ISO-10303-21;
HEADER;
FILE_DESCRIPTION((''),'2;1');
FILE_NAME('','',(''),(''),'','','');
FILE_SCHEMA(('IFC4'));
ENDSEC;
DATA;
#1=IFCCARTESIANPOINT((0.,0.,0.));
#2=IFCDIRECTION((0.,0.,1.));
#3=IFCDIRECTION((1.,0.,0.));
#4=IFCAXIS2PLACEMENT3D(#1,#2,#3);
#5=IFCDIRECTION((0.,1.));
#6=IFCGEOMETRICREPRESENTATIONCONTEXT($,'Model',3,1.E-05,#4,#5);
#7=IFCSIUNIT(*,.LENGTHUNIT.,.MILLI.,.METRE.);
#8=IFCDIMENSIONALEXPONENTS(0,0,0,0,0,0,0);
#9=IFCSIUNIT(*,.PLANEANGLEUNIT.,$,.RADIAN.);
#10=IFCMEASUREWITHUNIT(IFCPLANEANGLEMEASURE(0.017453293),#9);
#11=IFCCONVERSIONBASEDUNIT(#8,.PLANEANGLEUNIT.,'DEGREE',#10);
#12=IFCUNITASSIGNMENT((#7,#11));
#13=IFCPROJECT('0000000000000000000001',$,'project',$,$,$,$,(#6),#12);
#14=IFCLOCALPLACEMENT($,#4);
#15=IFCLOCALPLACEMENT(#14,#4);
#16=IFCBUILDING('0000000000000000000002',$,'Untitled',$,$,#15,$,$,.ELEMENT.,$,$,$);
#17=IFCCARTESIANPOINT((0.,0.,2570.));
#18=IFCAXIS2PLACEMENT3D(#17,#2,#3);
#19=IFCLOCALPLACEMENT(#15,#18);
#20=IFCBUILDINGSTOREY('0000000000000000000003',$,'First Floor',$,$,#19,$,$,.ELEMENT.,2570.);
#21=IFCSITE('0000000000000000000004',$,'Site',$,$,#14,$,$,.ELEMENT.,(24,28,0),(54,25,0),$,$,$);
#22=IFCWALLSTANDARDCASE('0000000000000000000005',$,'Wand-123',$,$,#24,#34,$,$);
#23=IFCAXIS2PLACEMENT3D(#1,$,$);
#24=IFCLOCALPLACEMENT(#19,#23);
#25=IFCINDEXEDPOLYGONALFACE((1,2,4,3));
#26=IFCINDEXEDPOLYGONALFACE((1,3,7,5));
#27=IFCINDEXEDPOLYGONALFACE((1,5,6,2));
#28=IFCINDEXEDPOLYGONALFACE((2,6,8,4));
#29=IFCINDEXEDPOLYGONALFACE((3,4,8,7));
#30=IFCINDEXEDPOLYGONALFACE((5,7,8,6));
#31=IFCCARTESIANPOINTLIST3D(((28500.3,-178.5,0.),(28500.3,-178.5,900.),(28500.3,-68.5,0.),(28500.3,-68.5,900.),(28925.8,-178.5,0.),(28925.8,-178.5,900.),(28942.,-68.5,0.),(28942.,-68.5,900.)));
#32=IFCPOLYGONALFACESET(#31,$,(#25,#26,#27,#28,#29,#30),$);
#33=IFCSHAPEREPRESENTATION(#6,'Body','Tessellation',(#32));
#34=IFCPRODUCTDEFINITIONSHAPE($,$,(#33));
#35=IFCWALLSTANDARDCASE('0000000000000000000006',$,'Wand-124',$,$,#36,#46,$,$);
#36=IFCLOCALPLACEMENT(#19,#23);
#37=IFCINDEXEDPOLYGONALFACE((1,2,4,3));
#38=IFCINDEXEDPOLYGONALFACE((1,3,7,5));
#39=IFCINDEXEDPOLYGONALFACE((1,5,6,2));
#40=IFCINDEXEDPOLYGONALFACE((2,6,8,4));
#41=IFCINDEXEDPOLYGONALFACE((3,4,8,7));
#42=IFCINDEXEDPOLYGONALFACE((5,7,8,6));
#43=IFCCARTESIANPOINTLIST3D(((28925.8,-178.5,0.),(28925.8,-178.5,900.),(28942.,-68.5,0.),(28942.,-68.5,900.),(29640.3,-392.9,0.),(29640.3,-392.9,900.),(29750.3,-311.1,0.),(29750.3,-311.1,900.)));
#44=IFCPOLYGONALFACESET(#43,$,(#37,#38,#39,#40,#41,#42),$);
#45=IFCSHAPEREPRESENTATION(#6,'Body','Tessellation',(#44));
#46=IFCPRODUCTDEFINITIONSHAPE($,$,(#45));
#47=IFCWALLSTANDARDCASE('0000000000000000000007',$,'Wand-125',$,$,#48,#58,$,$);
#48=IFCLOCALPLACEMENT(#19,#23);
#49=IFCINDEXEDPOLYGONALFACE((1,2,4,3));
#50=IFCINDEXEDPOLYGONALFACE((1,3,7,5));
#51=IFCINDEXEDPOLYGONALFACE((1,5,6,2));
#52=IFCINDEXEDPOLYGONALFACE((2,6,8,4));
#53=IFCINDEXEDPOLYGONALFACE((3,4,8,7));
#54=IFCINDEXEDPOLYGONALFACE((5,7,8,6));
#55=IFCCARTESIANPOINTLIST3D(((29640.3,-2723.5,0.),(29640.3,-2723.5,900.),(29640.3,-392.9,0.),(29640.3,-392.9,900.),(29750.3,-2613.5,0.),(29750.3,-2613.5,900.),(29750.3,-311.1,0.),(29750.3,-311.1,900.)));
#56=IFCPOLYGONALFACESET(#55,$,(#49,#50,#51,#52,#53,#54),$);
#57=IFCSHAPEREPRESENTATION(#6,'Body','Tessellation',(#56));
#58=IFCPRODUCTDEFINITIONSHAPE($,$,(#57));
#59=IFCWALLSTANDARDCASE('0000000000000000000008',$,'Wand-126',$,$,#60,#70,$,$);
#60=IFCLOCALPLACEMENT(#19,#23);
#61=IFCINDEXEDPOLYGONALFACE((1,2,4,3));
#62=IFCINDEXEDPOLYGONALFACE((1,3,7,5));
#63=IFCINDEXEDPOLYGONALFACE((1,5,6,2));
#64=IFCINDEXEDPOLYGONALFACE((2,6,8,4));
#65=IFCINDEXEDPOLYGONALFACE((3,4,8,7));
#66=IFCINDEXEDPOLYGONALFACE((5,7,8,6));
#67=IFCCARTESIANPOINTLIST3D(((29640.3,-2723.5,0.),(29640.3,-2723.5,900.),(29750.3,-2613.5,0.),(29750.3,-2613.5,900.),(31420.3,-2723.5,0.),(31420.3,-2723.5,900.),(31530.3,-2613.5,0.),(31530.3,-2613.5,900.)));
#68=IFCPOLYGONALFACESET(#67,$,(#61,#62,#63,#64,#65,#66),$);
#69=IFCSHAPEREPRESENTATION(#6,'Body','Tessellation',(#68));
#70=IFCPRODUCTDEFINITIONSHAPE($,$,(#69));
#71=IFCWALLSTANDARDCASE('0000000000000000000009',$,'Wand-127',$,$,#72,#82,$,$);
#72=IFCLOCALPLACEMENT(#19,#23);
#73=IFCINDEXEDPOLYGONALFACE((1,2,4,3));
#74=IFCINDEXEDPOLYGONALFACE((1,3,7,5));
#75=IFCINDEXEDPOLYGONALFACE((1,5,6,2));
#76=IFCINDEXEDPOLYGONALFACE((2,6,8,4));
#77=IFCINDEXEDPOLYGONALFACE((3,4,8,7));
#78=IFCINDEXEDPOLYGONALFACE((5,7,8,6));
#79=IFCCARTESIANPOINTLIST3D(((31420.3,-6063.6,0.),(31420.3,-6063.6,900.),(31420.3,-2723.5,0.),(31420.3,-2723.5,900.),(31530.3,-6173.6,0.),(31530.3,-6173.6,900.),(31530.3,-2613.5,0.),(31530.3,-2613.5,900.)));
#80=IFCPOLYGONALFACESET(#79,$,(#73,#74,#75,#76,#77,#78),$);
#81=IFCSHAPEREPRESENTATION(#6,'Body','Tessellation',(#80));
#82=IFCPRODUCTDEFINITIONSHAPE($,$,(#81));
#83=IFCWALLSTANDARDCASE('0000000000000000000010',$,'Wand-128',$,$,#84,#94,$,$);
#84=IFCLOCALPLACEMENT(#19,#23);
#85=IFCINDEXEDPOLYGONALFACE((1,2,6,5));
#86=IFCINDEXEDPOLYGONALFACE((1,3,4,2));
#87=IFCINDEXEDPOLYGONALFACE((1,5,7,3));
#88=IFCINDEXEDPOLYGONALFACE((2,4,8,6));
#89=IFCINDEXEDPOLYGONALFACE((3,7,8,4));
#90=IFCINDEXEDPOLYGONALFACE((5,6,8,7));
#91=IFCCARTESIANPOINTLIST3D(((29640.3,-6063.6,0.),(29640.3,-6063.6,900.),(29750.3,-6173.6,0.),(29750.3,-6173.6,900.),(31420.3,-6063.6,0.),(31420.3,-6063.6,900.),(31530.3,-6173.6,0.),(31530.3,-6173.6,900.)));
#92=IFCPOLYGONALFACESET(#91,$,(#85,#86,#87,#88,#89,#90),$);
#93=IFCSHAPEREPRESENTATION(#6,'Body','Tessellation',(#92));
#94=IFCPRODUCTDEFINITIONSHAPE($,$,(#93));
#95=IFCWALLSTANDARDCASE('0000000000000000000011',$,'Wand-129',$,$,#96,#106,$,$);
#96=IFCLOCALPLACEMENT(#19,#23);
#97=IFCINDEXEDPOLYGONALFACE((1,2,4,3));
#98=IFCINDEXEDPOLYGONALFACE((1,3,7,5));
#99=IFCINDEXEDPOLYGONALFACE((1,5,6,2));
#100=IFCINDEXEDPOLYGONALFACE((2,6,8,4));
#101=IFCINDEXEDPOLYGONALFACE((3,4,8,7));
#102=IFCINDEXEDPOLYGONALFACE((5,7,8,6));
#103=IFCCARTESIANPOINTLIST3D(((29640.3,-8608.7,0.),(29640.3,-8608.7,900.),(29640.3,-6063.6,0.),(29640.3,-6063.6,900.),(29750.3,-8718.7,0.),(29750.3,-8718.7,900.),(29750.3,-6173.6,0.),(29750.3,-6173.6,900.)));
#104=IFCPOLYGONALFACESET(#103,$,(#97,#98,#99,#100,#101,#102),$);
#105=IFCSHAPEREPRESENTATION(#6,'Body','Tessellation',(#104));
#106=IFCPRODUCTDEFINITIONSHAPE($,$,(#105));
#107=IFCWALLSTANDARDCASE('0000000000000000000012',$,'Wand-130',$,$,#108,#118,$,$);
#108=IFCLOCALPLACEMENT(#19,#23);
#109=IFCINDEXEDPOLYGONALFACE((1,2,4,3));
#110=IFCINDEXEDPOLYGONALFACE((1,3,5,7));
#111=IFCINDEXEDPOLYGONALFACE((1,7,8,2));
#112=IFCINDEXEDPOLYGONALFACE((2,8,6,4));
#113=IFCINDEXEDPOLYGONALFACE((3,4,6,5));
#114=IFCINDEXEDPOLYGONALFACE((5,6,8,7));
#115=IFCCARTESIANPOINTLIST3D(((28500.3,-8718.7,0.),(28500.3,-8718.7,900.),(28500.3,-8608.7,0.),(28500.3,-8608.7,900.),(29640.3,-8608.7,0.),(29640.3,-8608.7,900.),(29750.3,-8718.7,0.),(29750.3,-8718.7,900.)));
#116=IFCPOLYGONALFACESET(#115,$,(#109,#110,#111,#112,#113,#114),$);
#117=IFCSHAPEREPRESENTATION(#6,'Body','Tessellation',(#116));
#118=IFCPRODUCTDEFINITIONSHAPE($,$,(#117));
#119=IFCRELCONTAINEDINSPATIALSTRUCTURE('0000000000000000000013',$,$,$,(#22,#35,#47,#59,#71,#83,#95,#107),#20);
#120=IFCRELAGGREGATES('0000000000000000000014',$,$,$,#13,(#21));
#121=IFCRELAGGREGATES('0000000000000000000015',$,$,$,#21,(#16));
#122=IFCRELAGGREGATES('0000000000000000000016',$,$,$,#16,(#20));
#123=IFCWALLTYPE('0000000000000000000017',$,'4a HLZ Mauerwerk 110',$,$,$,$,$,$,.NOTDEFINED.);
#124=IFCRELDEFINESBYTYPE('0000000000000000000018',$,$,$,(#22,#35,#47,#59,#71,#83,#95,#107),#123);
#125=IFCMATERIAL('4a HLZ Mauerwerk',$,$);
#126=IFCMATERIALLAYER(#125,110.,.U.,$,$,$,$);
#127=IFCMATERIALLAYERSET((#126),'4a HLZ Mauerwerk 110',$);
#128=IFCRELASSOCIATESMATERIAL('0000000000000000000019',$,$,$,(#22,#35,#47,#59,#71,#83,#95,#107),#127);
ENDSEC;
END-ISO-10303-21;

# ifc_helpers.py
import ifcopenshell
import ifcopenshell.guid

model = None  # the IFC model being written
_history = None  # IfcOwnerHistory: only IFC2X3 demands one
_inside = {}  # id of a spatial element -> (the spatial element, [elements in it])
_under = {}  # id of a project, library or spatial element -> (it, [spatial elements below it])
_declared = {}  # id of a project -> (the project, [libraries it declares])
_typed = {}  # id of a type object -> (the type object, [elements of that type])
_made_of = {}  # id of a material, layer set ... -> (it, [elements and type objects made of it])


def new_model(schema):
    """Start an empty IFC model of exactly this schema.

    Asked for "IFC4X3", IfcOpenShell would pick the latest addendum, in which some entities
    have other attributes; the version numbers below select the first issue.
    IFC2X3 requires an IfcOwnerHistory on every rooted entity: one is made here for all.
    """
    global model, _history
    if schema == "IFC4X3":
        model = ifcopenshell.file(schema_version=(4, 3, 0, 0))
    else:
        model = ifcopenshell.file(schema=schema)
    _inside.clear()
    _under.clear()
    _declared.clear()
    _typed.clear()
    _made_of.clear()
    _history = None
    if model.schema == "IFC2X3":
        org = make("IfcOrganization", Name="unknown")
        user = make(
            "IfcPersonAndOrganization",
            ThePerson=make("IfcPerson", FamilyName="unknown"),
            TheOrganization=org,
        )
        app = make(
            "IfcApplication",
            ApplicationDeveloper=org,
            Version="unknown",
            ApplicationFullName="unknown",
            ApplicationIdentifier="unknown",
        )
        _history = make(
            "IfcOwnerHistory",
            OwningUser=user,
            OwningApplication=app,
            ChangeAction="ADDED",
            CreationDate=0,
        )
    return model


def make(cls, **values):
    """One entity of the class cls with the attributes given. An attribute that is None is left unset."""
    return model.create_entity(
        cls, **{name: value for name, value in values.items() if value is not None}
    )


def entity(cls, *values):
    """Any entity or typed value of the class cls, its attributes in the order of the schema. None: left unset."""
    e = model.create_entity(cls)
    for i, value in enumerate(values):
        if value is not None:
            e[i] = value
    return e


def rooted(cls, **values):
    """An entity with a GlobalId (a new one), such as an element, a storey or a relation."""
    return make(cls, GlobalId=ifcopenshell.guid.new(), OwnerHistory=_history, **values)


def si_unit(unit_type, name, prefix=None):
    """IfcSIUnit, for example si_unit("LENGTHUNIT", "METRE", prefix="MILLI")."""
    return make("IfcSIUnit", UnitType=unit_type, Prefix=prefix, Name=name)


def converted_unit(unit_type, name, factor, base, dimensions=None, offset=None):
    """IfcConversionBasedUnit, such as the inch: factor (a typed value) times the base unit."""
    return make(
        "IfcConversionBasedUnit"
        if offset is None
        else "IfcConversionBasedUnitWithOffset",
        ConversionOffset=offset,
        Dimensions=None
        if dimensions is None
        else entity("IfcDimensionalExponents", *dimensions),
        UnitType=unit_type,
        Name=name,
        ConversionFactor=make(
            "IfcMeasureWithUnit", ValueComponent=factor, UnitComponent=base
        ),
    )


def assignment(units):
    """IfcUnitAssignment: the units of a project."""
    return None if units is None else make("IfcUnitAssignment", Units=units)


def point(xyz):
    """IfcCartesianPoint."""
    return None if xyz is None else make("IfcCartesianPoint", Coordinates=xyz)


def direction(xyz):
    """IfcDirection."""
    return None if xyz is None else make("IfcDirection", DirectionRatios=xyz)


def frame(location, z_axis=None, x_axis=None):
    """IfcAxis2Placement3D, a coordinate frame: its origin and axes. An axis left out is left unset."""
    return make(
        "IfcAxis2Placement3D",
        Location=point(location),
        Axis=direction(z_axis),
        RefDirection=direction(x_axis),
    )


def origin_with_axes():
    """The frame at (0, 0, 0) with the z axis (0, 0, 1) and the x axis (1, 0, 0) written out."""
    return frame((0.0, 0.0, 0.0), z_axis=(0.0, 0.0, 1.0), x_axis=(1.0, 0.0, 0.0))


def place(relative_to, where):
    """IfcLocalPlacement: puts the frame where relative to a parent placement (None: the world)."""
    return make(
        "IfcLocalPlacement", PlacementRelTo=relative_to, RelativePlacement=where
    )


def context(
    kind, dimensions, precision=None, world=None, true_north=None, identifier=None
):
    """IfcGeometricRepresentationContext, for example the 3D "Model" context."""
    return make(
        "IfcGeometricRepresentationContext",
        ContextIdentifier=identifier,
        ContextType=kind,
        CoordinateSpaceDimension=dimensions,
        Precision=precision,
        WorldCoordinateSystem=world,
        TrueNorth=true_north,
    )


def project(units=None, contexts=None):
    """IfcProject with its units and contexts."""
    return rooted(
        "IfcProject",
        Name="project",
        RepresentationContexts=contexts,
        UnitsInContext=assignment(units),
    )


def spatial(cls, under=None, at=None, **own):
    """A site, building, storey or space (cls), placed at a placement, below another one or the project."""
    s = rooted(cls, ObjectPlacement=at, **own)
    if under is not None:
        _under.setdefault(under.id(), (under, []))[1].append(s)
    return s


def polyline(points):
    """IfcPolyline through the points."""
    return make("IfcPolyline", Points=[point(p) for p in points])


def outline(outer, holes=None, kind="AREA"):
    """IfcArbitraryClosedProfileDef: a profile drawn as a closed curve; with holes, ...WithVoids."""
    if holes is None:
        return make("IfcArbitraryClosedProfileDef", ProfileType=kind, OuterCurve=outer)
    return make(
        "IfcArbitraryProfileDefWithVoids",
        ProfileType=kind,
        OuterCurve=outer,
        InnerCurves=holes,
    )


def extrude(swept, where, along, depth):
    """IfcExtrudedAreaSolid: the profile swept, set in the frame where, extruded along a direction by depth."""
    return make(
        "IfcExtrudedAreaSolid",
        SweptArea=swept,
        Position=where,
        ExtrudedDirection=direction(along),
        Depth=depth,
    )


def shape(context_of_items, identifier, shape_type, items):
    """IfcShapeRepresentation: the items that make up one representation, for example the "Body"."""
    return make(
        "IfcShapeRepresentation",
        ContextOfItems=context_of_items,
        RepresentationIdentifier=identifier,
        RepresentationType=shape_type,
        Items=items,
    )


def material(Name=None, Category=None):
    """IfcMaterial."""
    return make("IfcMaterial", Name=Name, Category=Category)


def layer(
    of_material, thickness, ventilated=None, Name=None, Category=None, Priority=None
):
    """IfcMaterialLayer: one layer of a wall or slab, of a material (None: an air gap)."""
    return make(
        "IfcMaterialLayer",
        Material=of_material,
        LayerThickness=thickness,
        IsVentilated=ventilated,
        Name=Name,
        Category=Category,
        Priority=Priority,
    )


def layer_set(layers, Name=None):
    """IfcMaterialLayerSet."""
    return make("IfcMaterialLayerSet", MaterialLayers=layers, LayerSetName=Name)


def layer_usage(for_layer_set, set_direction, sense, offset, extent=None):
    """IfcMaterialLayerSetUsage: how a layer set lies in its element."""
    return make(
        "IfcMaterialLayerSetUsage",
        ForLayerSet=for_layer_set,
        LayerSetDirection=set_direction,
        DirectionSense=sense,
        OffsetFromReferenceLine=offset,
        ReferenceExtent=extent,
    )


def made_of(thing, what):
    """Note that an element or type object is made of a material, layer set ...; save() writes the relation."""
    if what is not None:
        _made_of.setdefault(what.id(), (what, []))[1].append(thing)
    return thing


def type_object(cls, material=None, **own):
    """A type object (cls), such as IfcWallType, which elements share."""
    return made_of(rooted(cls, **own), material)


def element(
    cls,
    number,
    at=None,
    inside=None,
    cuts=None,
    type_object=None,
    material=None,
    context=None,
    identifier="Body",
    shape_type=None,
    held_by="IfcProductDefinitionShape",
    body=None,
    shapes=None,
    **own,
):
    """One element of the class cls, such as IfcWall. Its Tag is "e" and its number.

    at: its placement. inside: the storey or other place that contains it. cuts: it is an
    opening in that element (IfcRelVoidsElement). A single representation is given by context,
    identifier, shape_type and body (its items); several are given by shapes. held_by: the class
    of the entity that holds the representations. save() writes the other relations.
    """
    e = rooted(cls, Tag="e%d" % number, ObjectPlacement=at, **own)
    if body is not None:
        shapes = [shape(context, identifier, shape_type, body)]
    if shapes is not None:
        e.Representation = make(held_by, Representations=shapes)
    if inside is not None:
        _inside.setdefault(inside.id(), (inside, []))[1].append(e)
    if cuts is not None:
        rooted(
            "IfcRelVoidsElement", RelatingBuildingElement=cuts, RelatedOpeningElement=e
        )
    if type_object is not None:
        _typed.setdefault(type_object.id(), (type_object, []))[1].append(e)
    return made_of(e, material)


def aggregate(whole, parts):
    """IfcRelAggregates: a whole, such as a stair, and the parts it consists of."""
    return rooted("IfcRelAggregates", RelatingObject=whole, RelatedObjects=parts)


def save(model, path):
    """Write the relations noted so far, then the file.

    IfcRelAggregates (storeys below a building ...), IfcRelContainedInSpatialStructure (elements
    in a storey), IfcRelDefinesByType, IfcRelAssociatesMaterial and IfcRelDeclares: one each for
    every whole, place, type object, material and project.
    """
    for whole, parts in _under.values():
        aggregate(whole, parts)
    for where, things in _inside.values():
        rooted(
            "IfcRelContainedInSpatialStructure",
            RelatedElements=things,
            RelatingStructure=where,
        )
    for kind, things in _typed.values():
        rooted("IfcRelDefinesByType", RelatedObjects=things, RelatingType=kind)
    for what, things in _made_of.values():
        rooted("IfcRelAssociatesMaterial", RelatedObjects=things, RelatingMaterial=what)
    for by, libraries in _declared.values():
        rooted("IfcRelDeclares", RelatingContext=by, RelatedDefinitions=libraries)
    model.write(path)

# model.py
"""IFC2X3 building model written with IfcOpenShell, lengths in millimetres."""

from ifc_helpers import new_model, entity, si_unit, converted_unit, direction, frame, origin_with_axes, place, context, project, spatial, polyline, outline, extrude, material, layer, layer_set, layer_usage, type_object, element, save


model = new_model("IFC2X3")

# Units and contexts
model_context = context("Model", 3, precision=1e-05, world=origin_with_axes(), true_north=direction((0.0, 1.0)))
ifc_project = project(units=[si_unit("LENGTHUNIT", "METRE", prefix="MILLI"), converted_unit("PLANEANGLEUNIT", "DEGREE", entity("IfcPlaneAngleMeasure", 0.017453293), si_unit("PLANEANGLEUNIT", "RADIAN"), dimensions=[0, 0, 0, 0, 0, 0, 0])], contexts=[model_context])

# Site, building, storey
site_placement = place(None, origin_with_axes())
site = spatial("IfcSite", under=ifc_project, at=site_placement, Name="Site", CompositionType="ELEMENT", RefLatitude=(24, 28, 0), RefLongitude=(54, 25, 0))
building_placement = place(site_placement, origin_with_axes())
building = spatial("IfcBuilding", under=site, at=building_placement, Name="Untitled", CompositionType="ELEMENT")
storey_placement = place(building_placement, frame((0.0, 0.0, 2570.0), z_axis=(0.0, 0.0, 1.0), x_axis=(1.0, 0.0, 0.0)))
storey = spatial("IfcBuildingStorey", under=building, at=storey_placement, Name="First Floor", CompositionType="ELEMENT", Elevation=2570.0)

# Shared definitions
ifc_material_1 = material(Name="4a HLZ Mauerwerk")

# Walls
ifc_layer_1 = layer(ifc_material_1, 110.0, ventilated="UNKNOWN")
ifc_layer_set_1 = layer_set([ifc_layer_1], Name="4a HLZ Mauerwerk 110")
ifc_layer_usage_1 = layer_usage(ifc_layer_set_1, "AXIS2", "NEGATIVE", 0.0)
wall_type_1 = type_object("IfcWallType", Name="4a HLZ Mauerwerk 110", PredefinedType="NOTDEFINED")
wall_1_placement = place(storey_placement, frame((28500.3, -68.5, 0.0), z_axis=(0.0, 0.0, 1.0), x_axis=(1.0, 0.0, 0.0)))
element("IfcWallStandardCase", 1, at=wall_1_placement, inside=storey, type_object=wall_type_1, material=ifc_layer_usage_1, Name="Wand-123", context=model_context, shape_type="SweptSolid", body=[
    extrude(outline(polyline([(0.0, -110.0), (425.6, -110.0), (441.7, 0.0), (0.0, 0.0), (0.0, -110.0)])), origin_with_axes(), (0.0, 0.0, 1.0), 900.0),
])
ifc_layer_usage_2 = layer_usage(ifc_layer_set_1, "AXIS2", "NEGATIVE", 0.0)
wall_2_placement = place(storey_placement, frame((28942.0, -68.5, 0.0), z_axis=(0.0, 0.0, 1.0), x_axis=(0.957788, -0.287475, 0.0)))
element("IfcWallStandardCase", 2, at=wall_2_placement, inside=storey, type_object=wall_type_1, material=ifc_layer_usage_2, Name="Wand-124", context=model_context, shape_type="SweptSolid", body=[
    extrude(outline(polyline([(16.2, -110.0), (762.1, -110.0), (843.9, 0.0), (0.0, 0.0), (16.2, -110.0)])), origin_with_axes(), (0.0, 0.0, 1.0), 900.0),
])
ifc_layer_usage_3 = layer_usage(ifc_layer_set_1, "AXIS2", "NEGATIVE", 0.0)
wall_3_placement = place(storey_placement, frame((29750.3, -311.1, 0.0), z_axis=(0.0, 0.0, 1.0), x_axis=(0.0, -1.0, 0.0)))
element("IfcWallStandardCase", 3, at=wall_3_placement, inside=storey, type_object=wall_type_1, material=ifc_layer_usage_3, Name="Wand-125", context=model_context, shape_type="SweptSolid", body=[
    extrude(outline(polyline([(81.8, -110.0), (2412.4, -110.0), (2302.4, 0.0), (0.0, 0.0), (81.8, -110.0)])), origin_with_axes(), (0.0, 0.0, 1.0), 900.0),
])
ifc_layer_usage_4 = layer_usage(ifc_layer_set_1, "AXIS2", "NEGATIVE", 0.0)
wall_4_placement = place(storey_placement, frame((29750.3, -2613.5, 0.0), z_axis=(0.0, 0.0, 1.0), x_axis=(1.0, 0.0, 0.0)))
element("IfcWallStandardCase", 4, at=wall_4_placement, inside=storey, type_object=wall_type_1, material=ifc_layer_usage_4, Name="Wand-126", context=model_context, shape_type="SweptSolid", body=[
    extrude(outline(polyline([(-110.0, -110.0), (1670.0, -110.0), (1780.0, 0.0), (0.0, 0.0), (-110.0, -110.0)])), origin_with_axes(), (0.0, 0.0, 1.0), 900.0),
])
ifc_layer_usage_5 = layer_usage(ifc_layer_set_1, "AXIS2", "NEGATIVE", 0.0)
wall_5_placement = place(storey_placement, frame((31530.3, -2613.5, 0.0), z_axis=(0.0, 0.0, 1.0), x_axis=(0.0, -1.0, 0.0)))
element("IfcWallStandardCase", 5, at=wall_5_placement, inside=storey, type_object=wall_type_1, material=ifc_layer_usage_5, Name="Wand-127", context=model_context, shape_type="SweptSolid", body=[
    extrude(outline(polyline([(110.0, -110.0), (3450.1, -110.0), (3560.1, 0.0), (0.0, 0.0), (110.0, -110.0)])), origin_with_axes(), (0.0, 0.0, 1.0), 900.0),
])
ifc_layer_usage_6 = layer_usage(ifc_layer_set_1, "AXIS2", "NEGATIVE", 0.0)
wall_6_placement = place(storey_placement, frame((31530.3, -6173.6, 0.0), z_axis=(0.0, 0.0, 1.0), x_axis=(-1.0, 0.0, 0.0)))
element("IfcWallStandardCase", 6, at=wall_6_placement, inside=storey, type_object=wall_type_1, material=ifc_layer_usage_6, Name="Wand-128", context=model_context, shape_type="SweptSolid", body=[
    extrude(outline(polyline([(110.0, -110.0), (1890.0, -110.0), (1780.0, 0.0), (0.0, 0.0), (110.0, -110.0)])), origin_with_axes(), (0.0, 0.0, 1.0), 900.0),
])
ifc_layer_usage_7 = layer_usage(ifc_layer_set_1, "AXIS2", "NEGATIVE", 0.0)
wall_7_placement = place(storey_placement, frame((29750.3, -6173.6, 0.0), z_axis=(0.0, 0.0, 1.0), x_axis=(0.0, -1.0, 0.0)))
element("IfcWallStandardCase", 7, at=wall_7_placement, inside=storey, type_object=wall_type_1, material=ifc_layer_usage_7, Name="Wand-129", context=model_context, shape_type="SweptSolid", body=[
    extrude(outline(polyline([(-110.0, -110.0), (2435.1, -110.0), (2545.1, 0.0), (0.0, 0.0), (-110.0, -110.0)])), origin_with_axes(), (0.0, 0.0, 1.0), 900.0),
])
ifc_layer_usage_8 = layer_usage(ifc_layer_set_1, "AXIS2", "NEGATIVE", 0.0)
wall_8_placement = place(storey_placement, frame((29750.3, -8718.7, 0.0), z_axis=(0.0, 0.0, 1.0), x_axis=(-1.0, 0.0, 0.0)))
element("IfcWallStandardCase", 8, at=wall_8_placement, inside=storey, type_object=wall_type_1, material=ifc_layer_usage_8, Name="Wand-130", context=model_context, shape_type="SweptSolid", body=[
    extrude(outline(polyline([(110.0, -110.0), (1250.0, -110.0), (1250.0, 0.0), (0.0, 0.0), (110.0, -110.0)])), origin_with_axes(), (0.0, 0.0, 1.0), 900.0),
])

save(model, "model.ifc")
